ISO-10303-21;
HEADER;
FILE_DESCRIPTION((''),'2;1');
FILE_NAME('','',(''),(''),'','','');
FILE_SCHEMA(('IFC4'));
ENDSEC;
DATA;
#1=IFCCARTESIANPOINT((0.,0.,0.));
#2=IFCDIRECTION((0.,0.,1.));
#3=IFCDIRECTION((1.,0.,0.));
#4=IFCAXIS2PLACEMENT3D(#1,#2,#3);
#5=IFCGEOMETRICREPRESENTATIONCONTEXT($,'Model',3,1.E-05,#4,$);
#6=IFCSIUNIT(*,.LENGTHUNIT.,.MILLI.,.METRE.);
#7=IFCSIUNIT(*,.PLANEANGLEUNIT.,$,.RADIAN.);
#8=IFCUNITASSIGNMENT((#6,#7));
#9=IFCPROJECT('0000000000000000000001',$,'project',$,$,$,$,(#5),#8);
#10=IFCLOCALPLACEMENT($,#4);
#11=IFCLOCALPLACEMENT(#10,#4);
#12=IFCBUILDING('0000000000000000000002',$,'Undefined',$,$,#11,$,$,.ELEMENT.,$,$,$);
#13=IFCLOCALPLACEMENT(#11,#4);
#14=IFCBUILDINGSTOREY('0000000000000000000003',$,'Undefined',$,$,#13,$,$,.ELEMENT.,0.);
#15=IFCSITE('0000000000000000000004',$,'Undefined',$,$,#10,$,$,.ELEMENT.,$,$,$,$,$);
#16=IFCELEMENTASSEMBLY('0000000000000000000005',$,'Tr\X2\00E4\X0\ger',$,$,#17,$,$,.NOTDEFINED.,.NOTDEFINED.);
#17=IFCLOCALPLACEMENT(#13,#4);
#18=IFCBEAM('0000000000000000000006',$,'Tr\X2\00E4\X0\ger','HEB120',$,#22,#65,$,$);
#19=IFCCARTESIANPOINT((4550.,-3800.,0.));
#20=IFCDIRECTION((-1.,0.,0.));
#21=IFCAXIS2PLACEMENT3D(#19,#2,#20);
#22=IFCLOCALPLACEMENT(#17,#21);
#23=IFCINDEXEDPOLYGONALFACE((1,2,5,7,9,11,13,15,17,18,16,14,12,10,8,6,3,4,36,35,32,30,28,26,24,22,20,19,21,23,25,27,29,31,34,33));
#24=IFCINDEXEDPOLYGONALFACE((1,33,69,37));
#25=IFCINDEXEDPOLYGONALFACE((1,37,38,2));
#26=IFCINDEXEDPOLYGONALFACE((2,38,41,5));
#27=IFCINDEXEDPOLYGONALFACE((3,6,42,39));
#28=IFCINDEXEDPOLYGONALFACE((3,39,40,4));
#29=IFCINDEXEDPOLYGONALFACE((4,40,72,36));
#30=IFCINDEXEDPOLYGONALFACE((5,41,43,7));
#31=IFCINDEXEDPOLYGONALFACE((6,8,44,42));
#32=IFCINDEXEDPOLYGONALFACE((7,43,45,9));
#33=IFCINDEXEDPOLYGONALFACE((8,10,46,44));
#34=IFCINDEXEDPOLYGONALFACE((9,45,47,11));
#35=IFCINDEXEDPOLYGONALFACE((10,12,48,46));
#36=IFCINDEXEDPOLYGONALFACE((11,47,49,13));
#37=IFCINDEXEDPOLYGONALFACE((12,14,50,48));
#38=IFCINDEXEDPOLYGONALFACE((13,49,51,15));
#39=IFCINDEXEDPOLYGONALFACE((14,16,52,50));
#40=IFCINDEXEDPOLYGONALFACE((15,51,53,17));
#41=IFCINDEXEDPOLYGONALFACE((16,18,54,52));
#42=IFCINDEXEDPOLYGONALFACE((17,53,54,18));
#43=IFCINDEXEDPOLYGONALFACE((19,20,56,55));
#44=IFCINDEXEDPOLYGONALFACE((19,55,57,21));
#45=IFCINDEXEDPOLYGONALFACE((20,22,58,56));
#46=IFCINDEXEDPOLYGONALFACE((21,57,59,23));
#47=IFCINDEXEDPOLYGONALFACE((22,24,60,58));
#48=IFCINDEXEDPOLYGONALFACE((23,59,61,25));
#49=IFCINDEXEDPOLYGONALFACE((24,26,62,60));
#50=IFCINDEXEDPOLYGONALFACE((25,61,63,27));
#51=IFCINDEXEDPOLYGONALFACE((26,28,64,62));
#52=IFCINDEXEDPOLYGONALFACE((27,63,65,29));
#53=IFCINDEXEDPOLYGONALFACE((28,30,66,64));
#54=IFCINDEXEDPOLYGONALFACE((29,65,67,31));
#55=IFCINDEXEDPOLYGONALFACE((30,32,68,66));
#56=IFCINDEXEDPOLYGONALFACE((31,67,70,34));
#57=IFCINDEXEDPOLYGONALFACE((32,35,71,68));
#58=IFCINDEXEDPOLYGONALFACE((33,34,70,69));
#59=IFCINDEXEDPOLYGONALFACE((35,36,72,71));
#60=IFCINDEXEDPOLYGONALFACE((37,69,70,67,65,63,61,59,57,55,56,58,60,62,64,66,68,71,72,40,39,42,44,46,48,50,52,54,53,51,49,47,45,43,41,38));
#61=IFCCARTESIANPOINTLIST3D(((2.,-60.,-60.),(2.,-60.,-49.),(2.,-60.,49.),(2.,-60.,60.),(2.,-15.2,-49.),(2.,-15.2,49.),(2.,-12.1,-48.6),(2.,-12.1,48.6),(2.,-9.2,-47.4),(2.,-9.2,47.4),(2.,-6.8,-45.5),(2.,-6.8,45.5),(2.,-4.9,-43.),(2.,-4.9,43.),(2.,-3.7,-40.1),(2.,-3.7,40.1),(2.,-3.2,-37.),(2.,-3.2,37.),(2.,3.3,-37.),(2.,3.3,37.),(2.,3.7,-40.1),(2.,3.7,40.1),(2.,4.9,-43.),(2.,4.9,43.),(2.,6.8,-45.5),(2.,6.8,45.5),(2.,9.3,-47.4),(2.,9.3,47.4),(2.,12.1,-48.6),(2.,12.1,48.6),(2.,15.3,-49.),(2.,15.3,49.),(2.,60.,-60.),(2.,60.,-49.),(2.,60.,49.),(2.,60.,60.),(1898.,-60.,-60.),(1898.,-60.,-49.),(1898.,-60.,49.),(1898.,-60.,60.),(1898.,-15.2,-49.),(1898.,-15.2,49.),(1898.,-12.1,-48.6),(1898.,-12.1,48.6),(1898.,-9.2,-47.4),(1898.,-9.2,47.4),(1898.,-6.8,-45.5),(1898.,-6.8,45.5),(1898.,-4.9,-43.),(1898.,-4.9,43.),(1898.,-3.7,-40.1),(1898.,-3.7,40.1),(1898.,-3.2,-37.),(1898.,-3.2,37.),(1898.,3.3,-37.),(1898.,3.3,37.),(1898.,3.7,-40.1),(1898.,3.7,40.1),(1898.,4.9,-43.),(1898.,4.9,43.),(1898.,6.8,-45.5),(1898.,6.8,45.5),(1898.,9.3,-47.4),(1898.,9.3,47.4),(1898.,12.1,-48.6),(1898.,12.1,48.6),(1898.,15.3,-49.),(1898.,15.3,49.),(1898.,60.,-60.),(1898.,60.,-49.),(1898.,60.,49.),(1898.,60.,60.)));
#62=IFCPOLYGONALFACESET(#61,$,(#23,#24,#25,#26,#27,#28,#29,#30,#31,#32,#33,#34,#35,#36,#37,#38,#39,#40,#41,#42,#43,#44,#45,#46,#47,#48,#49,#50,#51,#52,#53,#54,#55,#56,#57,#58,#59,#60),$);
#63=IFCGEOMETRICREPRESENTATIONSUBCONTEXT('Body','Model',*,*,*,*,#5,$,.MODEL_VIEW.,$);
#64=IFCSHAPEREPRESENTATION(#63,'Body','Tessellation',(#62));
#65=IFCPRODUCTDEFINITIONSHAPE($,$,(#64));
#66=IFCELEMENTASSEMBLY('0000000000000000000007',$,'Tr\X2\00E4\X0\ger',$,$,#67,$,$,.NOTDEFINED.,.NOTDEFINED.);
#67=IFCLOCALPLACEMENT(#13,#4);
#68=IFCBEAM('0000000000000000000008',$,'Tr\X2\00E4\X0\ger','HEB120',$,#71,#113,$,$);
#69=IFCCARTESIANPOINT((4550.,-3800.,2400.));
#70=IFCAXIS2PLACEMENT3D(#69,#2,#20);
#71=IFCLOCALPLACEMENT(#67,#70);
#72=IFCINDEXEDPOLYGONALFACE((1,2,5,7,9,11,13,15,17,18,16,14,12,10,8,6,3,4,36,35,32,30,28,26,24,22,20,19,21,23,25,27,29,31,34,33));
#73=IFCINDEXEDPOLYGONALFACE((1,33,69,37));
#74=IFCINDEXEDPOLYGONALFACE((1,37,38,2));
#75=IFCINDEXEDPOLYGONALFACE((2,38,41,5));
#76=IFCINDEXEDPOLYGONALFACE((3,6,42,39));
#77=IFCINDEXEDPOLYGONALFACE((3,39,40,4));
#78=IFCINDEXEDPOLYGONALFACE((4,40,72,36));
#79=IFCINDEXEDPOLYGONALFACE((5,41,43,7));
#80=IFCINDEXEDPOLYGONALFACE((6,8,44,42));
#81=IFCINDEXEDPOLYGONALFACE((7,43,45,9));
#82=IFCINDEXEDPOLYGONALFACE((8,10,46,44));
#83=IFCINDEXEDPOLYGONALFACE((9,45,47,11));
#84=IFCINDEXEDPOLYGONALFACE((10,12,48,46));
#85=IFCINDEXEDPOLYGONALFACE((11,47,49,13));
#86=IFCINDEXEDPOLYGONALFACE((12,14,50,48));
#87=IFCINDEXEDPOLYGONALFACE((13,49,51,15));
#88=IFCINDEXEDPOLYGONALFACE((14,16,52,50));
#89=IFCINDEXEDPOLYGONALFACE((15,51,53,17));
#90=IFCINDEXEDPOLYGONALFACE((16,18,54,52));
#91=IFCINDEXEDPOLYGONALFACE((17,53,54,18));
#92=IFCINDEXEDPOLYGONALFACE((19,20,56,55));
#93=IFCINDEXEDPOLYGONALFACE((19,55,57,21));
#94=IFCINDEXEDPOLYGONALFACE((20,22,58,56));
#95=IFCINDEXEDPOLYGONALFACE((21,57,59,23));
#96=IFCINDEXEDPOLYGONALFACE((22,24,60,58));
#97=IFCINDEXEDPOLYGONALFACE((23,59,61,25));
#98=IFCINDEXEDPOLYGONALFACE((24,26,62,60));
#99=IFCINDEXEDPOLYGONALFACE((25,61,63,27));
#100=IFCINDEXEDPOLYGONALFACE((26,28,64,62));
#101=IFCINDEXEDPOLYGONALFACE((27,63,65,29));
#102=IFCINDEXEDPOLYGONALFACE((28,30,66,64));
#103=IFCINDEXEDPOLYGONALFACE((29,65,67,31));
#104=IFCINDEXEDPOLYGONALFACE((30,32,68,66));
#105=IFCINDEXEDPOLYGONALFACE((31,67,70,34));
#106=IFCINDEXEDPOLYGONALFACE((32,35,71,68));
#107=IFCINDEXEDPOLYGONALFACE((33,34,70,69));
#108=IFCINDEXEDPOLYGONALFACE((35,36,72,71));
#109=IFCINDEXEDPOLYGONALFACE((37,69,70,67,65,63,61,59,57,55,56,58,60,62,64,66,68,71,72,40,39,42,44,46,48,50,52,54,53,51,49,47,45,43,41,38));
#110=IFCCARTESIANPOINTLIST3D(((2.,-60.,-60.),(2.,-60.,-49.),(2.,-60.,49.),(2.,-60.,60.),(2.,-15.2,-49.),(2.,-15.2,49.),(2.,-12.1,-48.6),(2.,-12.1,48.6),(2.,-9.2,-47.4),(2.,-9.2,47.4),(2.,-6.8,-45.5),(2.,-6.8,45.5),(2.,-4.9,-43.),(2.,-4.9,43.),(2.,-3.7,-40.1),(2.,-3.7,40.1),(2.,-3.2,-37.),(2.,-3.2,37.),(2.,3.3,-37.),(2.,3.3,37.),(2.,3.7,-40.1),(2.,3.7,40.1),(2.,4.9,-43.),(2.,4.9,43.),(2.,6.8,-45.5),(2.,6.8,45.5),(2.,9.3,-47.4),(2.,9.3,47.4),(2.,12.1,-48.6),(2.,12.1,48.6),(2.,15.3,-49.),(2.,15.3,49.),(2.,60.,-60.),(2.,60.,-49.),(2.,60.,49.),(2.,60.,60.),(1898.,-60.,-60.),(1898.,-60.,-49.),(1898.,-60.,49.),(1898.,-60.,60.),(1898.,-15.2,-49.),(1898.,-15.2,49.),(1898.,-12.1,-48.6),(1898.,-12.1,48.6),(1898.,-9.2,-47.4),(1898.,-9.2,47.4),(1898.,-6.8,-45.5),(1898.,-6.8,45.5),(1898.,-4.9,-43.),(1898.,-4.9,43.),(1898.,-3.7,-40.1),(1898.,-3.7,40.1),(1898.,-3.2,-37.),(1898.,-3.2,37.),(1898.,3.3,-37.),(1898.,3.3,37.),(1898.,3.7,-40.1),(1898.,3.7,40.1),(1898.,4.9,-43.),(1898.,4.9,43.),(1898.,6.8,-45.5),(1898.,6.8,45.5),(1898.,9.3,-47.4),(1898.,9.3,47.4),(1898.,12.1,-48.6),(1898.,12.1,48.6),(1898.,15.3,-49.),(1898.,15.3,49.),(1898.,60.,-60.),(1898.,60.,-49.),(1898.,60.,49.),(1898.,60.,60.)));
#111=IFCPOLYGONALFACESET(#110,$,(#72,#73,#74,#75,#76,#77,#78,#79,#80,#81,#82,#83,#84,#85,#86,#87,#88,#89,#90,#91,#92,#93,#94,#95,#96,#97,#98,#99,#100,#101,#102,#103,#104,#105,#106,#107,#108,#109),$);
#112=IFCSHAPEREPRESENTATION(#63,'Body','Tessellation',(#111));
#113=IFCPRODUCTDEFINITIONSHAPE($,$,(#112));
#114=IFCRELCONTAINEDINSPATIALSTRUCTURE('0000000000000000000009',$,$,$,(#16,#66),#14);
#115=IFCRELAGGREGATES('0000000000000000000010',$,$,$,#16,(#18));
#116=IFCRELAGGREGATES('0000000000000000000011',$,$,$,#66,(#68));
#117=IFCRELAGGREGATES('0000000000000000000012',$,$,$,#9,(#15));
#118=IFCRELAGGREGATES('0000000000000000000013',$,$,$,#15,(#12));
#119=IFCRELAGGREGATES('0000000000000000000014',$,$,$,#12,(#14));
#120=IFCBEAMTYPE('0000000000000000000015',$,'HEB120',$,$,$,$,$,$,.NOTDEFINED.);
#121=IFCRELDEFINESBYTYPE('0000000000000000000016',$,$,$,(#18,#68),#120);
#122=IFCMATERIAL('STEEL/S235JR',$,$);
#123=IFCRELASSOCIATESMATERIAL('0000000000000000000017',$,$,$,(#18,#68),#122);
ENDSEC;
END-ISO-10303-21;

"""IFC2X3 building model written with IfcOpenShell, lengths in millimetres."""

from ifc_helpers import new_model, si_unit, frame, origin_with_axes, origin_2d_with_axis, place, context, subcontext, project, spatial, i_section, extrude, clip, halfspace, material, type_object, element, aggregate, save


model = new_model("IFC2X3")

# Units and contexts
model_context = context("Model", 3, precision=1e-05, world=origin_with_axes())
body_context = subcontext(model_context, "Body", "Model", "MODEL_VIEW")
ifc_project = project(units=[si_unit("LENGTHUNIT", "METRE", prefix="MILLI"), si_unit("PLANEANGLEUNIT", "RADIAN")], contexts=[model_context])

# Site, building, storey
site_placement = place(None, origin_with_axes())
site = spatial("IfcSite", under=ifc_project, at=site_placement, Name="Undefined", CompositionType="ELEMENT")
building_placement = place(site_placement, origin_with_axes())
building = spatial("IfcBuilding", under=site, at=building_placement, Name="Undefined", CompositionType="ELEMENT")
storey_placement = place(building_placement, origin_with_axes())
storey = spatial("IfcBuildingStorey", under=building, at=storey_placement, Name="Undefined", CompositionType="ELEMENT", Elevation=0.0)

# Shared definitions
ifc_material_1 = material(Name="STEEL/S235JR")

# Element assembly, beam
beam_type_1 = type_object("IfcBeamType", Name="HEB120", PredefinedType="NOTDEFINED")
assembly_1_placement = place(storey_placement, origin_with_axes())
assembly_1 = element("IfcElementAssembly", 1, at=assembly_1_placement, inside=storey, Name="Träger", AssemblyPlace="NOTDEFINED", PredefinedType="NOTDEFINED")
beam_1_placement = place(assembly_1_placement, frame((4550.0, -3800.0, 0.0), z_axis=(0.0, 0.0, 1.0), x_axis=(-1.0, 0.0, 0.0)))
beam_1 = element("IfcBeam", 2, at=beam_1_placement, type_object=beam_type_1, material=ifc_material_1, Name="Träger", Description="HEB120", context=body_context, shape_type="Clipping", body=[
    clip(clip(extrude(i_section(OverallWidth=120.0, OverallDepth=120.0, WebThickness=6.5, FlangeThickness=11.0, FilletRadius=12.0, at=origin_2d_with_axis()), frame((1910.0, 0.0, 0.0), z_axis=(-1.0, 0.0, 0.0), x_axis=(0.0, -1.0, 0.0)), (0.0, 0.0, 1.0), 1910.0), halfspace(frame((1898.0, 0.0, -60.0), z_axis=(-1.0, 0.0, 0.0), x_axis=(0.0, 1.0, 0.0)), True)), halfspace(frame((2.0, 0.0, -60.0), z_axis=(1.0, 0.0, 0.0), x_axis=(0.0, -1.0, 0.0)), True)),
])
aggregate(assembly_1, [beam_1])

# Element assembly, beam
assembly_2_placement = place(storey_placement, origin_with_axes())
assembly_2 = element("IfcElementAssembly", 3, at=assembly_2_placement, inside=storey, Name="Träger", AssemblyPlace="NOTDEFINED", PredefinedType="NOTDEFINED")
beam_2_placement = place(assembly_2_placement, frame((4550.0, -3800.0, 2400.0), z_axis=(0.0, 0.0, 1.0), x_axis=(-1.0, 0.0, 0.0)))
beam_2 = element("IfcBeam", 4, at=beam_2_placement, type_object=beam_type_1, material=ifc_material_1, Name="Träger", Description="HEB120", context=body_context, shape_type="Clipping", body=[
    clip(clip(extrude(i_section(OverallWidth=120.0, OverallDepth=120.0, WebThickness=6.5, FlangeThickness=11.0, FilletRadius=12.0, at=origin_2d_with_axis()), frame((1910.0, 0.0, 0.0), z_axis=(-1.0, 0.0, 0.0), x_axis=(0.0, -1.0, 0.0)), (0.0, 0.0, 1.0), 1910.0), halfspace(frame((1898.0, 0.0, -60.0), z_axis=(-1.0, 0.0, 0.0), x_axis=(0.0, 1.0, 0.0)), True)), halfspace(frame((2.0, 0.0, -60.0), z_axis=(1.0, 0.0, 0.0), x_axis=(0.0, -1.0, 0.0)), True)),
])

aggregate(assembly_2, [beam_2])

save(model, "model.ifc")
